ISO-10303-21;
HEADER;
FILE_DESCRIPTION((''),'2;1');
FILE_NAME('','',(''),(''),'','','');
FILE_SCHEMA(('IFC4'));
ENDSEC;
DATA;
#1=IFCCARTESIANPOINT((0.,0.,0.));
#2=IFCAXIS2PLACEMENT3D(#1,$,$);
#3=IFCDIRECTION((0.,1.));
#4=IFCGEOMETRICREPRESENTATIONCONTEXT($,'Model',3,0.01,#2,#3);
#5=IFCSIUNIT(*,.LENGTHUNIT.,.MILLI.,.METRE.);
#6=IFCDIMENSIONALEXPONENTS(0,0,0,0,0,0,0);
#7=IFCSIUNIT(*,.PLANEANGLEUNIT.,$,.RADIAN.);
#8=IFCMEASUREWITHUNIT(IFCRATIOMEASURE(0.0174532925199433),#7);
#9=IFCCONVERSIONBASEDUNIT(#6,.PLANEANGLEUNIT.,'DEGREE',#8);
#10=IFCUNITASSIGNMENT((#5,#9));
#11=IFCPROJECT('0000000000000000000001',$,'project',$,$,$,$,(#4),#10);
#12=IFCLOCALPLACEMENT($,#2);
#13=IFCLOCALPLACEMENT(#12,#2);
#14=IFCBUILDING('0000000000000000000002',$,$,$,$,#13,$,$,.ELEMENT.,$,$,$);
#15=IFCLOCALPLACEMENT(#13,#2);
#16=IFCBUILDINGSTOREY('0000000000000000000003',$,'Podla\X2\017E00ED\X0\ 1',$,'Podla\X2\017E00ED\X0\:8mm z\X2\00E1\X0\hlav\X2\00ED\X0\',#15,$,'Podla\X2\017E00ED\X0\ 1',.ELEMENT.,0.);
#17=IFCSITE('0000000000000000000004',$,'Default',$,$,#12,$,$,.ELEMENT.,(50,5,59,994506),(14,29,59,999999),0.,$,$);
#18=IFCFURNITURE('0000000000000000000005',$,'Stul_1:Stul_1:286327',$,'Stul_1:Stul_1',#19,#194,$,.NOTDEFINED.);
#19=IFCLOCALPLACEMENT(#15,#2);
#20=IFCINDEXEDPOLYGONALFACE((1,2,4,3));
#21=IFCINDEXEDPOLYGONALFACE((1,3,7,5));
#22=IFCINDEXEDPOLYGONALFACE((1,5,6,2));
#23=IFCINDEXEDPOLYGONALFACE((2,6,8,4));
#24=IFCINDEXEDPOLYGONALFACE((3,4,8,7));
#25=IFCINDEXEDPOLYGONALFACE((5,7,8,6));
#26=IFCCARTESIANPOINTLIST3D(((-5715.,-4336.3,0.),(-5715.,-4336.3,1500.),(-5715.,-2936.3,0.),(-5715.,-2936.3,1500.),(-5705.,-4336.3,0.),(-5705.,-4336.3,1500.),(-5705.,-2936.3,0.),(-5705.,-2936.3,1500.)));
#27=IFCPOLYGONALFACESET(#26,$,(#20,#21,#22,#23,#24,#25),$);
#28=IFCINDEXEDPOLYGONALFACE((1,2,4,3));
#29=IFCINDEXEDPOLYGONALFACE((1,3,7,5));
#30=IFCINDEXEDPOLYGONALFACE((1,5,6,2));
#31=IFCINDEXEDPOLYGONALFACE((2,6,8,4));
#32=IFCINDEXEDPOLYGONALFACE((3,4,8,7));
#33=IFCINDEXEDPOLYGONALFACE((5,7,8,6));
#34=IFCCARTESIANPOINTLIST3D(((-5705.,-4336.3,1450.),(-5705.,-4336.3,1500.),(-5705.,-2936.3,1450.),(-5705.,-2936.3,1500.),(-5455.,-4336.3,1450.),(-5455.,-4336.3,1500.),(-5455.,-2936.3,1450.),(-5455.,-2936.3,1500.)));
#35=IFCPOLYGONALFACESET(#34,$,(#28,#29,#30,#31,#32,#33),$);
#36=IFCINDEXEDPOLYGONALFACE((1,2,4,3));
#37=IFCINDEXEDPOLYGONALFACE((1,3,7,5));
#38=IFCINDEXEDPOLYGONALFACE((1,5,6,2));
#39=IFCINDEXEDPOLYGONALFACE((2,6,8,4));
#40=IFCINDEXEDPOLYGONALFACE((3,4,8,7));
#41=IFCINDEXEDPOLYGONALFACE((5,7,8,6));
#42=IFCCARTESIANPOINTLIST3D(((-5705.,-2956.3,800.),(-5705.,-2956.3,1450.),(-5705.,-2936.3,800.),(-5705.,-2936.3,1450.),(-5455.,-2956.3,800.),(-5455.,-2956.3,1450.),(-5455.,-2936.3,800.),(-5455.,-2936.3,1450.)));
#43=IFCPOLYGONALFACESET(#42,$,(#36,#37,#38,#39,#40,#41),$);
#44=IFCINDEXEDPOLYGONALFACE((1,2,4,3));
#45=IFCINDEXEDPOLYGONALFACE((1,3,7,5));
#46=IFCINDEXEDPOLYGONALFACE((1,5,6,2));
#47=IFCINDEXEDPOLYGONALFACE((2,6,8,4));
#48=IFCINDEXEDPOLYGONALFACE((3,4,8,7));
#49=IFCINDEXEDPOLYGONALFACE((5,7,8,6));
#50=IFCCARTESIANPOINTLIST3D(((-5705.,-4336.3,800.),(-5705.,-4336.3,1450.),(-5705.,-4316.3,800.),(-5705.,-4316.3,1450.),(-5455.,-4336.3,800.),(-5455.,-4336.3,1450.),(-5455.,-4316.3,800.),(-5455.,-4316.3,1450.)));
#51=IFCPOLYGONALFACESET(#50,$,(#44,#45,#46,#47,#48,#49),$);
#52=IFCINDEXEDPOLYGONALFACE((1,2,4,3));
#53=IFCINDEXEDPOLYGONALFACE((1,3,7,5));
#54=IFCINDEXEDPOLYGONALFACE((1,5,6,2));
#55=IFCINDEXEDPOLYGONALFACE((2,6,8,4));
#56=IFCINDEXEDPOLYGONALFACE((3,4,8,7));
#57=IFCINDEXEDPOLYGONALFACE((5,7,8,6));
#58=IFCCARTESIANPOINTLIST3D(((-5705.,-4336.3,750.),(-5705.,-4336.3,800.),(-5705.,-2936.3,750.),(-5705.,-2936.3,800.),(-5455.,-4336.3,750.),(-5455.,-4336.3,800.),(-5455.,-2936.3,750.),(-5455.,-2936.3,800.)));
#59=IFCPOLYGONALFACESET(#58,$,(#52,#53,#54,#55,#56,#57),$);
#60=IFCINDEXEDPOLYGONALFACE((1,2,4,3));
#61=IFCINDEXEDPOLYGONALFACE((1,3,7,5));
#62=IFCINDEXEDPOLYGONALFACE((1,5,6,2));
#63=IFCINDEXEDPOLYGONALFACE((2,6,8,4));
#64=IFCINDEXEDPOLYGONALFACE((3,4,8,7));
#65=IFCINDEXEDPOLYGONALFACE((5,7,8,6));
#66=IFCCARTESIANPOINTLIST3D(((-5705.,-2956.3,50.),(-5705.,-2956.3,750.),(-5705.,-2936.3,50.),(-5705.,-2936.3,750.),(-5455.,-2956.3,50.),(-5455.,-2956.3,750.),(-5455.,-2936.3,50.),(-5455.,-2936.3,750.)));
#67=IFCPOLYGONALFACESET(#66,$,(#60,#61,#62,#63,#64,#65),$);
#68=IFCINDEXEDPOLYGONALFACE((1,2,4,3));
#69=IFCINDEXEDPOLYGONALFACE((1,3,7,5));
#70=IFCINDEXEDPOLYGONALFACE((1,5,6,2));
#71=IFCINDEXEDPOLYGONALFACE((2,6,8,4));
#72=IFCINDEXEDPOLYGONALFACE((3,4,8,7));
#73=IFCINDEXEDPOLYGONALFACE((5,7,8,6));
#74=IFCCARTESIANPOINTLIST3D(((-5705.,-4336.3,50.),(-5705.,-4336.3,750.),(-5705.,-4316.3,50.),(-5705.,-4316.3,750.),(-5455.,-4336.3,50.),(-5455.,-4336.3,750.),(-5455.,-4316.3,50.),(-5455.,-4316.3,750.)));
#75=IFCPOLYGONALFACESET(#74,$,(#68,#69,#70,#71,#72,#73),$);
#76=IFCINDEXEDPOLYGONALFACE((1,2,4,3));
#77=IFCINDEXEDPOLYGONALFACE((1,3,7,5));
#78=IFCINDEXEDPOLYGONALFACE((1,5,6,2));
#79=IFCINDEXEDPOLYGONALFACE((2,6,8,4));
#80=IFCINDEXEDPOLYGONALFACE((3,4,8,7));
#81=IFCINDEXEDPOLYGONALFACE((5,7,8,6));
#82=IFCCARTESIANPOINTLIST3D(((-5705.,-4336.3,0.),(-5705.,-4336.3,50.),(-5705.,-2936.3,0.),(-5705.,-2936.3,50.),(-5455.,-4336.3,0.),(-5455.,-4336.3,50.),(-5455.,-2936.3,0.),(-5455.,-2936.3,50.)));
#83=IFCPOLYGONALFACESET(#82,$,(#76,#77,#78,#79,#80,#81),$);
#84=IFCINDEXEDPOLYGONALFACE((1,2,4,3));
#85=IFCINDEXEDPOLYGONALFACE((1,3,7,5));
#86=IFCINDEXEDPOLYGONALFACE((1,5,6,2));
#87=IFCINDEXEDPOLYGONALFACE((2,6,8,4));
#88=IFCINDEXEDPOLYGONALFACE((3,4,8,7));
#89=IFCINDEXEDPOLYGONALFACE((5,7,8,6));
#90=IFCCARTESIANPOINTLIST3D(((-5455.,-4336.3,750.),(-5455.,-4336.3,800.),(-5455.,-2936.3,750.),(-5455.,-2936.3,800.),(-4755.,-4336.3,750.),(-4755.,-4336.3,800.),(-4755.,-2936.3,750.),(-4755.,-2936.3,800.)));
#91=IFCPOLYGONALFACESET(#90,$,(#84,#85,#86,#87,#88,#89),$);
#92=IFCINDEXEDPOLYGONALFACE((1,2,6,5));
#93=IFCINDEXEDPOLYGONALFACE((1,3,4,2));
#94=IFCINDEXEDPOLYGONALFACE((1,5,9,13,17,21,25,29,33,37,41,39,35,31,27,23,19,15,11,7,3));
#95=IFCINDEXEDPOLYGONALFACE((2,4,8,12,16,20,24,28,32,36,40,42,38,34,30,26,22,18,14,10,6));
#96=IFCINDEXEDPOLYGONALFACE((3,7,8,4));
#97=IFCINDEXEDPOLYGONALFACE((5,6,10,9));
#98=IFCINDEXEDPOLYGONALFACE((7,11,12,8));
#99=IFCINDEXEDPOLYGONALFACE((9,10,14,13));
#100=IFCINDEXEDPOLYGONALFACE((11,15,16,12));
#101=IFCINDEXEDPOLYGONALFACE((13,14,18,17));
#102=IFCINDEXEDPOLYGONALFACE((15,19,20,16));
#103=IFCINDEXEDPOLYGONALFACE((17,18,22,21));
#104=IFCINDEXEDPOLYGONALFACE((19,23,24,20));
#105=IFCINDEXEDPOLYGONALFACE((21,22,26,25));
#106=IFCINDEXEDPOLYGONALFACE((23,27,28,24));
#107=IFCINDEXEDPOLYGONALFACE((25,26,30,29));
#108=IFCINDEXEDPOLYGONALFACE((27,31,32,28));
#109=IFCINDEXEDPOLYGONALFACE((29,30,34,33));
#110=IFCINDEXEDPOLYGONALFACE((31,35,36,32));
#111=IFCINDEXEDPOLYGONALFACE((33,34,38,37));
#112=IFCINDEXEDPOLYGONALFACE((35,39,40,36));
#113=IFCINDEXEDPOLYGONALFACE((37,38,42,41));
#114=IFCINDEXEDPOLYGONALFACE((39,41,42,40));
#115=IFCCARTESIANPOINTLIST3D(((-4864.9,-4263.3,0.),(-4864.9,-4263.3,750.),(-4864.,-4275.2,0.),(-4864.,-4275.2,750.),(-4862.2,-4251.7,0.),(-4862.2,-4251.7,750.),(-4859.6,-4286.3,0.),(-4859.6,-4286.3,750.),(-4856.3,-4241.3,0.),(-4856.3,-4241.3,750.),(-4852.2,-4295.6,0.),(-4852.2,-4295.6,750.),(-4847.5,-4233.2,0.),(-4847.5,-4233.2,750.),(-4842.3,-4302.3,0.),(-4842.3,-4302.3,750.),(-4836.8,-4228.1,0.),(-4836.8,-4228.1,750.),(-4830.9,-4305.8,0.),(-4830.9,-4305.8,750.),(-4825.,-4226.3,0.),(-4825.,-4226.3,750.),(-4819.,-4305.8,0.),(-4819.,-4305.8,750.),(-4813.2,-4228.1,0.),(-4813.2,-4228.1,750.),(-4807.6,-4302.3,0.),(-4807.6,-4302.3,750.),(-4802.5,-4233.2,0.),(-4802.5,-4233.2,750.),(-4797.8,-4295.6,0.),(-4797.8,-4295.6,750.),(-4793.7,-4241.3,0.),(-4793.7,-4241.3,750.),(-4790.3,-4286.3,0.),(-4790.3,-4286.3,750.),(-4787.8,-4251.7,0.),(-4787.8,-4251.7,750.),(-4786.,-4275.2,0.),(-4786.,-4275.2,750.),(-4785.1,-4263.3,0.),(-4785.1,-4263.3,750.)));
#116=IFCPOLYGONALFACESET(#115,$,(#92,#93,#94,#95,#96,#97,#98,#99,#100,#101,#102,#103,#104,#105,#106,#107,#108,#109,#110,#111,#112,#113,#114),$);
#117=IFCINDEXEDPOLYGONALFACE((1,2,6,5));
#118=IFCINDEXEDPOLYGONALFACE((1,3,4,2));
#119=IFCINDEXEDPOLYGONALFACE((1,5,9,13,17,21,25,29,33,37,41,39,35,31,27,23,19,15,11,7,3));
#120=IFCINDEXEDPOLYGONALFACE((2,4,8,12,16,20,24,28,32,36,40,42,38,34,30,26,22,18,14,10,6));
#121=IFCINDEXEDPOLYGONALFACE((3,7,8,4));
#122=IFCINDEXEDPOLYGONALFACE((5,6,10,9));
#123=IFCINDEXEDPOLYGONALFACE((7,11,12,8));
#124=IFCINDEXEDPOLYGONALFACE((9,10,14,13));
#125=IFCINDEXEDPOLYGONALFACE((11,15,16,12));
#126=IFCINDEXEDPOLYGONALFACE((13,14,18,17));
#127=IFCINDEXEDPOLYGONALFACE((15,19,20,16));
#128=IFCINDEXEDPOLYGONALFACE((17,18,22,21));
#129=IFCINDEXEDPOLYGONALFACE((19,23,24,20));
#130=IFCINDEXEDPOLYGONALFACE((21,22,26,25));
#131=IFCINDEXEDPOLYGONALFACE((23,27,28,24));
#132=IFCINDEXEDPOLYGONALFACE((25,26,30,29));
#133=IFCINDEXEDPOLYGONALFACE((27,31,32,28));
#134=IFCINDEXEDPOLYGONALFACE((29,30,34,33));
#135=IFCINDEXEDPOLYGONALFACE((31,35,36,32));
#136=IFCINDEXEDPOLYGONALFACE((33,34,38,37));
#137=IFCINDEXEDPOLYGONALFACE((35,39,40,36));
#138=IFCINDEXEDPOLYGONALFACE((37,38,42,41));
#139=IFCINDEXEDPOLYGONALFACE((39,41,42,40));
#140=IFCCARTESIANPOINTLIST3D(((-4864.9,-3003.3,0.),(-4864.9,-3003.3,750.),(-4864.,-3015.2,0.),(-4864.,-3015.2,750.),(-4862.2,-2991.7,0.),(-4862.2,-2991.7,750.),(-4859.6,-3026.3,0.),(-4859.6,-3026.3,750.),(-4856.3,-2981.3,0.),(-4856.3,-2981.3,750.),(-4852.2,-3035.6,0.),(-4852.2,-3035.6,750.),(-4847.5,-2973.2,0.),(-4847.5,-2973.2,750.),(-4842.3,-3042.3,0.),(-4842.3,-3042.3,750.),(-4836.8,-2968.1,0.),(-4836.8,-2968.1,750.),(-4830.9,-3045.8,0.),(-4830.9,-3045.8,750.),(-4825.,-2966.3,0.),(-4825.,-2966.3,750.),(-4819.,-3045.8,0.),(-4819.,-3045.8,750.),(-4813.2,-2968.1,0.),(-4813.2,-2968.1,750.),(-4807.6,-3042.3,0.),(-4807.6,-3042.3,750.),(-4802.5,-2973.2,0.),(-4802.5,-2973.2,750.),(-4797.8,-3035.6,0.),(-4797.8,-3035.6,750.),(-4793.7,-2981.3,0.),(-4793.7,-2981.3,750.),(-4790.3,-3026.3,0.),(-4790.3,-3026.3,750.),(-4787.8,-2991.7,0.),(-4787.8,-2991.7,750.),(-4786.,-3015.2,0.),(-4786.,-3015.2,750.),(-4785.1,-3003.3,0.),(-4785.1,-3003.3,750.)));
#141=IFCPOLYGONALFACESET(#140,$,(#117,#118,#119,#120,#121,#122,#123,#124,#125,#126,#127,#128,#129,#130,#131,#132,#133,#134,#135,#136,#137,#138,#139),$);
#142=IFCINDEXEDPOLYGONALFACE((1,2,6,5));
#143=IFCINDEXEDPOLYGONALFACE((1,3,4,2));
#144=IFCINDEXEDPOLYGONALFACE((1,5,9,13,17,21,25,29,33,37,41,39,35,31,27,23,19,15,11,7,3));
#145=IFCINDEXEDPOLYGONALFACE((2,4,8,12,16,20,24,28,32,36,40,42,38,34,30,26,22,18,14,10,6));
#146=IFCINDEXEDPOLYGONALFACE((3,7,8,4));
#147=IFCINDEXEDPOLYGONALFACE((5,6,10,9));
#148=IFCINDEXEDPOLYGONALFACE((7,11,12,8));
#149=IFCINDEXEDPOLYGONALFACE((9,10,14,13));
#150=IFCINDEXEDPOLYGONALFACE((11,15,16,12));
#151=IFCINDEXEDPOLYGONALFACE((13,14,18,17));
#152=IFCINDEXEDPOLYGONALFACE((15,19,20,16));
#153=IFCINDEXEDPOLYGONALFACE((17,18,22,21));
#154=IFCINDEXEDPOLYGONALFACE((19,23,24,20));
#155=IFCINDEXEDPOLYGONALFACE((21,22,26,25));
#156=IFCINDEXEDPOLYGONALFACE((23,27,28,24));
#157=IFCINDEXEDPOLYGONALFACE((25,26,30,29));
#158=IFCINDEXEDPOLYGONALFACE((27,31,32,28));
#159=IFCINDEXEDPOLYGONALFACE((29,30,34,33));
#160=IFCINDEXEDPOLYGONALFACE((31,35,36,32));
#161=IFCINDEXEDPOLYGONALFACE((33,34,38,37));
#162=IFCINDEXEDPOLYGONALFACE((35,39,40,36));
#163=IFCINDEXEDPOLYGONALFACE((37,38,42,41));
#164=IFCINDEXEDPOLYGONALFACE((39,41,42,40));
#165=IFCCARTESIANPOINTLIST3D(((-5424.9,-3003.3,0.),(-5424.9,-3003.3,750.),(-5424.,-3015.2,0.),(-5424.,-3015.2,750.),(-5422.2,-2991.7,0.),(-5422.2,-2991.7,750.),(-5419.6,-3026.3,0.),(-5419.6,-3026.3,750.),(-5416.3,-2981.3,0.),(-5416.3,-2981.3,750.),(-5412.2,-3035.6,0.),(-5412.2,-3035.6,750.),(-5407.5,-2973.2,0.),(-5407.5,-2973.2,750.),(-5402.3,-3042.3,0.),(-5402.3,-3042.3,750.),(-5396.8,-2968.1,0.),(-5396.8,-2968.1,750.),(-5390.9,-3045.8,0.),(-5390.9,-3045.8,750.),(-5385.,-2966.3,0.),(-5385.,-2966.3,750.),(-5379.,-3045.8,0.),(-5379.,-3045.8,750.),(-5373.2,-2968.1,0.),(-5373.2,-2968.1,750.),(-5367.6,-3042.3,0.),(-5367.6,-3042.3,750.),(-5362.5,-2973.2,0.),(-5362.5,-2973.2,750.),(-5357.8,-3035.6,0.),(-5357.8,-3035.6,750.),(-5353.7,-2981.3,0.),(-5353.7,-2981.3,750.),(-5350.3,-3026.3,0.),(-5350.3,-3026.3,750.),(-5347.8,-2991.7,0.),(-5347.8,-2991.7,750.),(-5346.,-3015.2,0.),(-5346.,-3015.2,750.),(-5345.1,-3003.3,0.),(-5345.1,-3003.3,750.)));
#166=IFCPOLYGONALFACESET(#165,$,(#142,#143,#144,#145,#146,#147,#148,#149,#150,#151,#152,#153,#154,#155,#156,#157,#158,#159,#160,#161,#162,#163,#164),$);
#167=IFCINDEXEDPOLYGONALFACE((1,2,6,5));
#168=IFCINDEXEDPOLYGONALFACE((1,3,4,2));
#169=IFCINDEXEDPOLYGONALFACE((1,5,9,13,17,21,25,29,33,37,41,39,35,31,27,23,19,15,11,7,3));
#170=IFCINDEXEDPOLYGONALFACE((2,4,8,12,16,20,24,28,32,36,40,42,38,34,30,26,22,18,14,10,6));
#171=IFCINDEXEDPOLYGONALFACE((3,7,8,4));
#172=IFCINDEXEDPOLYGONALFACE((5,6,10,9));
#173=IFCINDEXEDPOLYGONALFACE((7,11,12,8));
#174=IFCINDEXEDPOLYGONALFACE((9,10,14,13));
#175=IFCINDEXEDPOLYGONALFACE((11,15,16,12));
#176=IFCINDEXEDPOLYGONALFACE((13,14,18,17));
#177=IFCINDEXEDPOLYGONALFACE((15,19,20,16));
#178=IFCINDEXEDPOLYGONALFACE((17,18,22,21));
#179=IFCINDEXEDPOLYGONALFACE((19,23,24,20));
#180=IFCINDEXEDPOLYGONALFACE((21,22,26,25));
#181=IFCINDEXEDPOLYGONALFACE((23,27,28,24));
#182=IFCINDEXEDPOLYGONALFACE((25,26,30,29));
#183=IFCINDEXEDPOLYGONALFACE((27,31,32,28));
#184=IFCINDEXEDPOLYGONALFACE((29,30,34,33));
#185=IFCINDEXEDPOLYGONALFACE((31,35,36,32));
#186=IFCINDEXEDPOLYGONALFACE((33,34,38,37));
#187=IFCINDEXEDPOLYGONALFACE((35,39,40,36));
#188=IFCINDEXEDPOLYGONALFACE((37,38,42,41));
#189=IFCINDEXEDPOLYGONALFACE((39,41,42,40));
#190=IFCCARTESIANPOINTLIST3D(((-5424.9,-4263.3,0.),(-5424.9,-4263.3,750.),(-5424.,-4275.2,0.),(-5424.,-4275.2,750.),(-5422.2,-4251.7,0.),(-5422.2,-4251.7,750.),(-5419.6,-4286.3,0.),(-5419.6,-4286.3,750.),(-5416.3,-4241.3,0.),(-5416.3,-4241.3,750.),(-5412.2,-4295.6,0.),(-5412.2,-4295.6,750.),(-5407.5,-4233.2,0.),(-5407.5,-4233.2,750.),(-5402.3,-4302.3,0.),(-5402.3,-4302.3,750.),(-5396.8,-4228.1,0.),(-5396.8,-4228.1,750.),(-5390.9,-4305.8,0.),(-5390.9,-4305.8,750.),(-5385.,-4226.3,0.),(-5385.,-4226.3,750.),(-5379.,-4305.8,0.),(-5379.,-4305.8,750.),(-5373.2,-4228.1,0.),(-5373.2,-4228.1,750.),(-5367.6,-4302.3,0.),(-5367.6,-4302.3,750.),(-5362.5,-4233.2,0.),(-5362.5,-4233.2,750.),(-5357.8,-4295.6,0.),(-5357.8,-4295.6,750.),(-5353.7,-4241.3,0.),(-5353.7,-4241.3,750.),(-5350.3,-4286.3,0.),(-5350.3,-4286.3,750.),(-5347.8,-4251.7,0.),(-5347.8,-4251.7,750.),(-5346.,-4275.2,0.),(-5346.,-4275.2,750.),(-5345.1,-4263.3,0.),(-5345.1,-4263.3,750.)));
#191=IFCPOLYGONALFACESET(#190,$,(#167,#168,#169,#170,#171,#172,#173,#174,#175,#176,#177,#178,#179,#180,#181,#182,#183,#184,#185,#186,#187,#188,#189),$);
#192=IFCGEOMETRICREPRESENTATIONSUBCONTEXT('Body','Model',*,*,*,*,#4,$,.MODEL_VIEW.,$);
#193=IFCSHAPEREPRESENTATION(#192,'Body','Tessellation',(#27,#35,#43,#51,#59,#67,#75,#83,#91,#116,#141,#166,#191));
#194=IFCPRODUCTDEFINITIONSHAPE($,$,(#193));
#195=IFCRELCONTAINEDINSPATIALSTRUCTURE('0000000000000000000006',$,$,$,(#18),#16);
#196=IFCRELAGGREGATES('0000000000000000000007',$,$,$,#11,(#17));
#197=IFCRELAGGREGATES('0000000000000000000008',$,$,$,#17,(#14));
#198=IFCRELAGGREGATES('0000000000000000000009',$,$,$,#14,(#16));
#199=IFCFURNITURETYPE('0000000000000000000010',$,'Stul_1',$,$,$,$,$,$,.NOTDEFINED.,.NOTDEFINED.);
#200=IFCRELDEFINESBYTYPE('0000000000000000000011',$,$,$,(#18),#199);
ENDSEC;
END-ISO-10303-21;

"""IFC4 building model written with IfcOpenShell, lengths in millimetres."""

from ifc_helpers import new_model, entity, si_unit, converted_unit, direction, frame, frame_2d, origin, origin_2d_with_axis, place, context, subcontext, project, spatial, rectangle, circle, extrude, source, transform, mapped, type_object, type_shapes, element, save


model = new_model("IFC4")

# Units and contexts
model_context = context("Model", 3, precision=0.01, world=origin(), true_north=direction((0.0, 1.0)))
body_context = subcontext(model_context, "Body", "Model", "MODEL_VIEW")
ifc_project = project(units=[si_unit("LENGTHUNIT", "METRE", prefix="MILLI"), converted_unit("PLANEANGLEUNIT", "DEGREE", entity("IfcRatioMeasure", 0.0174532925199433), si_unit("PLANEANGLEUNIT", "RADIAN"), dimensions=[0, 0, 0, 0, 0, 0, 0])], contexts=[model_context])

# Site, building, storey
site_placement = place(None, origin())
site = spatial("IfcSite", under=ifc_project, at=site_placement, Name="Default", CompositionType="ELEMENT", RefLatitude=(50, 5, 59, 994506), RefLongitude=(14, 29, 59, 999999), RefElevation=0.0)
building_placement = place(site_placement, origin())
building = spatial("IfcBuilding", under=site, at=building_placement, CompositionType="ELEMENT")
storey_placement = place(building_placement, origin())
storey = spatial("IfcBuildingStorey", under=building, at=storey_placement, Name="Podlaží 1", ObjectType="Podlaží:8mm záhlaví", LongName="Podlaží 1", CompositionType="ELEMENT", Elevation=0.0)

# Furniture
furniture_type = type_object("IfcFurnitureType", Name="Stul_1", AssemblyPlace="NOTDEFINED", PredefinedType="NOTDEFINED")
shared_shape_1 = source(origin(), body_context, "Body", "SweptSolid", [
    extrude(rectangle(XDim=1400.0, YDim=10.0, at=origin_2d_with_axis()), frame((0.0, 605.0, 0.0), z_axis=(0.0, 0.0, 1.0), x_axis=(-1.0, 0.0, 0.0)), (0.0, 0.0, 1.0), 1500.0),
    extrude(rectangle(XDim=1400.0, YDim=250.0, at=frame_2d((0.0, 0.0), x_axis=(1.0, 0.0))), frame((0.0, 475.0, 1450.0), z_axis=(0.0, 0.0, 1.0), x_axis=(-1.0, 0.0, 0.0)), (0.0, 0.0, 1.0), 50.0),
    extrude(rectangle(XDim=20.0, YDim=250.0, at=origin_2d_with_axis()), frame((690.0, 475.0, 800.0), z_axis=(0.0, 0.0, 1.0), x_axis=(-1.0, 0.0, 0.0)), (0.0, 0.0, 1.0), 650.0),
    extrude(rectangle(XDim=20.0, YDim=250.0, at=frame_2d((0.0, 0.0), x_axis=(1.0, 0.0))), frame((-690.0, 475.0, 800.0), z_axis=(0.0, 0.0, 1.0), x_axis=(-1.0, 0.0, 0.0)), (0.0, 0.0, 1.0), 650.0),
    extrude(rectangle(XDim=1400.0, YDim=250.0, at=origin_2d_with_axis()), frame((0.0, 475.0, 750.0), z_axis=(0.0, 0.0, 1.0), x_axis=(-1.0, 0.0, 0.0)), (0.0, 0.0, 1.0), 50.0),
    extrude(rectangle(XDim=20.0, YDim=250.0, at=origin_2d_with_axis()), frame((690.0, 475.0, 50.0), z_axis=(0.0, 0.0, 1.0), x_axis=(-1.0, 0.0, 0.0)), (0.0, 0.0, 1.0), 700.0),
    extrude(rectangle(XDim=20.0, YDim=250.0, at=frame_2d((0.0, 0.0), x_axis=(1.0, 0.0))), frame((-690.0, 475.0, 50.0), z_axis=(0.0, 0.0, 1.0), x_axis=(-1.0, 0.0, 0.0)), (0.0, 0.0, 1.0), 700.0),
    extrude(rectangle(XDim=1400.0, YDim=250.0, at=origin_2d_with_axis()), frame((0.0, 475.0, 0.0), z_axis=(0.0, 0.0, 1.0), x_axis=(-1.0, 0.0, 0.0)), (0.0, 0.0, 1.0), 50.0),
    extrude(rectangle(XDim=1400.0, YDim=700.0, at=origin_2d_with_axis()), frame((0.0, 0.0, 750.0), z_axis=(0.0, 0.0, 1.0), x_axis=(-1.0, 0.0, 0.0)), (0.0, 0.0, 1.0), 50.0),
    extrude(circle(Radius=40.0, at=frame_2d((0.0, 0.0), x_axis=(1.0, 0.0))), frame((-630.0, -280.0, 0.0)), (0.0, 0.0, 1.0), 750.0),
    extrude(circle(Radius=40.0, at=frame_2d((0.0, 0.0), x_axis=(1.0, 0.0))), frame((630.0, -280.0, 0.0)), (0.0, 0.0, 1.0), 750.0),
    extrude(circle(Radius=40.0, at=frame_2d((0.0, 0.0), x_axis=(1.0, 0.0))), frame((630.0, 280.0, 0.0)), (0.0, 0.0, 1.0), 750.0),
    extrude(circle(Radius=40.0, at=frame_2d((0.0, 0.0), x_axis=(1.0, 0.0))), frame((-630.0, 280.0, 0.0)), (0.0, 0.0, 1.0), 750.0),
])
type_shapes(furniture_type, [shared_shape_1])
for number, where, z_axis, x_axis, name in (
    (1, (-5105.0, -3636.3, 0.0), (0.0, 0.0, 1.0), (0.0, 1.0, 0.0), "Stul_1:Stul_1:286327"),
):
    element("IfcFurniture", number, at=place(storey_placement, frame(where, z_axis=z_axis, x_axis=x_axis)), inside=storey, type_object=furniture_type, Name=name, ObjectType="Stul_1:Stul_1", PredefinedType="NOTDEFINED", context=body_context, shape_type="MappedRepresentation", body=[
        mapped(shared_shape_1, transform((0.0, 0.0, 0.0), scale=1.0)),
    ])

save(model, "model.ifc")
